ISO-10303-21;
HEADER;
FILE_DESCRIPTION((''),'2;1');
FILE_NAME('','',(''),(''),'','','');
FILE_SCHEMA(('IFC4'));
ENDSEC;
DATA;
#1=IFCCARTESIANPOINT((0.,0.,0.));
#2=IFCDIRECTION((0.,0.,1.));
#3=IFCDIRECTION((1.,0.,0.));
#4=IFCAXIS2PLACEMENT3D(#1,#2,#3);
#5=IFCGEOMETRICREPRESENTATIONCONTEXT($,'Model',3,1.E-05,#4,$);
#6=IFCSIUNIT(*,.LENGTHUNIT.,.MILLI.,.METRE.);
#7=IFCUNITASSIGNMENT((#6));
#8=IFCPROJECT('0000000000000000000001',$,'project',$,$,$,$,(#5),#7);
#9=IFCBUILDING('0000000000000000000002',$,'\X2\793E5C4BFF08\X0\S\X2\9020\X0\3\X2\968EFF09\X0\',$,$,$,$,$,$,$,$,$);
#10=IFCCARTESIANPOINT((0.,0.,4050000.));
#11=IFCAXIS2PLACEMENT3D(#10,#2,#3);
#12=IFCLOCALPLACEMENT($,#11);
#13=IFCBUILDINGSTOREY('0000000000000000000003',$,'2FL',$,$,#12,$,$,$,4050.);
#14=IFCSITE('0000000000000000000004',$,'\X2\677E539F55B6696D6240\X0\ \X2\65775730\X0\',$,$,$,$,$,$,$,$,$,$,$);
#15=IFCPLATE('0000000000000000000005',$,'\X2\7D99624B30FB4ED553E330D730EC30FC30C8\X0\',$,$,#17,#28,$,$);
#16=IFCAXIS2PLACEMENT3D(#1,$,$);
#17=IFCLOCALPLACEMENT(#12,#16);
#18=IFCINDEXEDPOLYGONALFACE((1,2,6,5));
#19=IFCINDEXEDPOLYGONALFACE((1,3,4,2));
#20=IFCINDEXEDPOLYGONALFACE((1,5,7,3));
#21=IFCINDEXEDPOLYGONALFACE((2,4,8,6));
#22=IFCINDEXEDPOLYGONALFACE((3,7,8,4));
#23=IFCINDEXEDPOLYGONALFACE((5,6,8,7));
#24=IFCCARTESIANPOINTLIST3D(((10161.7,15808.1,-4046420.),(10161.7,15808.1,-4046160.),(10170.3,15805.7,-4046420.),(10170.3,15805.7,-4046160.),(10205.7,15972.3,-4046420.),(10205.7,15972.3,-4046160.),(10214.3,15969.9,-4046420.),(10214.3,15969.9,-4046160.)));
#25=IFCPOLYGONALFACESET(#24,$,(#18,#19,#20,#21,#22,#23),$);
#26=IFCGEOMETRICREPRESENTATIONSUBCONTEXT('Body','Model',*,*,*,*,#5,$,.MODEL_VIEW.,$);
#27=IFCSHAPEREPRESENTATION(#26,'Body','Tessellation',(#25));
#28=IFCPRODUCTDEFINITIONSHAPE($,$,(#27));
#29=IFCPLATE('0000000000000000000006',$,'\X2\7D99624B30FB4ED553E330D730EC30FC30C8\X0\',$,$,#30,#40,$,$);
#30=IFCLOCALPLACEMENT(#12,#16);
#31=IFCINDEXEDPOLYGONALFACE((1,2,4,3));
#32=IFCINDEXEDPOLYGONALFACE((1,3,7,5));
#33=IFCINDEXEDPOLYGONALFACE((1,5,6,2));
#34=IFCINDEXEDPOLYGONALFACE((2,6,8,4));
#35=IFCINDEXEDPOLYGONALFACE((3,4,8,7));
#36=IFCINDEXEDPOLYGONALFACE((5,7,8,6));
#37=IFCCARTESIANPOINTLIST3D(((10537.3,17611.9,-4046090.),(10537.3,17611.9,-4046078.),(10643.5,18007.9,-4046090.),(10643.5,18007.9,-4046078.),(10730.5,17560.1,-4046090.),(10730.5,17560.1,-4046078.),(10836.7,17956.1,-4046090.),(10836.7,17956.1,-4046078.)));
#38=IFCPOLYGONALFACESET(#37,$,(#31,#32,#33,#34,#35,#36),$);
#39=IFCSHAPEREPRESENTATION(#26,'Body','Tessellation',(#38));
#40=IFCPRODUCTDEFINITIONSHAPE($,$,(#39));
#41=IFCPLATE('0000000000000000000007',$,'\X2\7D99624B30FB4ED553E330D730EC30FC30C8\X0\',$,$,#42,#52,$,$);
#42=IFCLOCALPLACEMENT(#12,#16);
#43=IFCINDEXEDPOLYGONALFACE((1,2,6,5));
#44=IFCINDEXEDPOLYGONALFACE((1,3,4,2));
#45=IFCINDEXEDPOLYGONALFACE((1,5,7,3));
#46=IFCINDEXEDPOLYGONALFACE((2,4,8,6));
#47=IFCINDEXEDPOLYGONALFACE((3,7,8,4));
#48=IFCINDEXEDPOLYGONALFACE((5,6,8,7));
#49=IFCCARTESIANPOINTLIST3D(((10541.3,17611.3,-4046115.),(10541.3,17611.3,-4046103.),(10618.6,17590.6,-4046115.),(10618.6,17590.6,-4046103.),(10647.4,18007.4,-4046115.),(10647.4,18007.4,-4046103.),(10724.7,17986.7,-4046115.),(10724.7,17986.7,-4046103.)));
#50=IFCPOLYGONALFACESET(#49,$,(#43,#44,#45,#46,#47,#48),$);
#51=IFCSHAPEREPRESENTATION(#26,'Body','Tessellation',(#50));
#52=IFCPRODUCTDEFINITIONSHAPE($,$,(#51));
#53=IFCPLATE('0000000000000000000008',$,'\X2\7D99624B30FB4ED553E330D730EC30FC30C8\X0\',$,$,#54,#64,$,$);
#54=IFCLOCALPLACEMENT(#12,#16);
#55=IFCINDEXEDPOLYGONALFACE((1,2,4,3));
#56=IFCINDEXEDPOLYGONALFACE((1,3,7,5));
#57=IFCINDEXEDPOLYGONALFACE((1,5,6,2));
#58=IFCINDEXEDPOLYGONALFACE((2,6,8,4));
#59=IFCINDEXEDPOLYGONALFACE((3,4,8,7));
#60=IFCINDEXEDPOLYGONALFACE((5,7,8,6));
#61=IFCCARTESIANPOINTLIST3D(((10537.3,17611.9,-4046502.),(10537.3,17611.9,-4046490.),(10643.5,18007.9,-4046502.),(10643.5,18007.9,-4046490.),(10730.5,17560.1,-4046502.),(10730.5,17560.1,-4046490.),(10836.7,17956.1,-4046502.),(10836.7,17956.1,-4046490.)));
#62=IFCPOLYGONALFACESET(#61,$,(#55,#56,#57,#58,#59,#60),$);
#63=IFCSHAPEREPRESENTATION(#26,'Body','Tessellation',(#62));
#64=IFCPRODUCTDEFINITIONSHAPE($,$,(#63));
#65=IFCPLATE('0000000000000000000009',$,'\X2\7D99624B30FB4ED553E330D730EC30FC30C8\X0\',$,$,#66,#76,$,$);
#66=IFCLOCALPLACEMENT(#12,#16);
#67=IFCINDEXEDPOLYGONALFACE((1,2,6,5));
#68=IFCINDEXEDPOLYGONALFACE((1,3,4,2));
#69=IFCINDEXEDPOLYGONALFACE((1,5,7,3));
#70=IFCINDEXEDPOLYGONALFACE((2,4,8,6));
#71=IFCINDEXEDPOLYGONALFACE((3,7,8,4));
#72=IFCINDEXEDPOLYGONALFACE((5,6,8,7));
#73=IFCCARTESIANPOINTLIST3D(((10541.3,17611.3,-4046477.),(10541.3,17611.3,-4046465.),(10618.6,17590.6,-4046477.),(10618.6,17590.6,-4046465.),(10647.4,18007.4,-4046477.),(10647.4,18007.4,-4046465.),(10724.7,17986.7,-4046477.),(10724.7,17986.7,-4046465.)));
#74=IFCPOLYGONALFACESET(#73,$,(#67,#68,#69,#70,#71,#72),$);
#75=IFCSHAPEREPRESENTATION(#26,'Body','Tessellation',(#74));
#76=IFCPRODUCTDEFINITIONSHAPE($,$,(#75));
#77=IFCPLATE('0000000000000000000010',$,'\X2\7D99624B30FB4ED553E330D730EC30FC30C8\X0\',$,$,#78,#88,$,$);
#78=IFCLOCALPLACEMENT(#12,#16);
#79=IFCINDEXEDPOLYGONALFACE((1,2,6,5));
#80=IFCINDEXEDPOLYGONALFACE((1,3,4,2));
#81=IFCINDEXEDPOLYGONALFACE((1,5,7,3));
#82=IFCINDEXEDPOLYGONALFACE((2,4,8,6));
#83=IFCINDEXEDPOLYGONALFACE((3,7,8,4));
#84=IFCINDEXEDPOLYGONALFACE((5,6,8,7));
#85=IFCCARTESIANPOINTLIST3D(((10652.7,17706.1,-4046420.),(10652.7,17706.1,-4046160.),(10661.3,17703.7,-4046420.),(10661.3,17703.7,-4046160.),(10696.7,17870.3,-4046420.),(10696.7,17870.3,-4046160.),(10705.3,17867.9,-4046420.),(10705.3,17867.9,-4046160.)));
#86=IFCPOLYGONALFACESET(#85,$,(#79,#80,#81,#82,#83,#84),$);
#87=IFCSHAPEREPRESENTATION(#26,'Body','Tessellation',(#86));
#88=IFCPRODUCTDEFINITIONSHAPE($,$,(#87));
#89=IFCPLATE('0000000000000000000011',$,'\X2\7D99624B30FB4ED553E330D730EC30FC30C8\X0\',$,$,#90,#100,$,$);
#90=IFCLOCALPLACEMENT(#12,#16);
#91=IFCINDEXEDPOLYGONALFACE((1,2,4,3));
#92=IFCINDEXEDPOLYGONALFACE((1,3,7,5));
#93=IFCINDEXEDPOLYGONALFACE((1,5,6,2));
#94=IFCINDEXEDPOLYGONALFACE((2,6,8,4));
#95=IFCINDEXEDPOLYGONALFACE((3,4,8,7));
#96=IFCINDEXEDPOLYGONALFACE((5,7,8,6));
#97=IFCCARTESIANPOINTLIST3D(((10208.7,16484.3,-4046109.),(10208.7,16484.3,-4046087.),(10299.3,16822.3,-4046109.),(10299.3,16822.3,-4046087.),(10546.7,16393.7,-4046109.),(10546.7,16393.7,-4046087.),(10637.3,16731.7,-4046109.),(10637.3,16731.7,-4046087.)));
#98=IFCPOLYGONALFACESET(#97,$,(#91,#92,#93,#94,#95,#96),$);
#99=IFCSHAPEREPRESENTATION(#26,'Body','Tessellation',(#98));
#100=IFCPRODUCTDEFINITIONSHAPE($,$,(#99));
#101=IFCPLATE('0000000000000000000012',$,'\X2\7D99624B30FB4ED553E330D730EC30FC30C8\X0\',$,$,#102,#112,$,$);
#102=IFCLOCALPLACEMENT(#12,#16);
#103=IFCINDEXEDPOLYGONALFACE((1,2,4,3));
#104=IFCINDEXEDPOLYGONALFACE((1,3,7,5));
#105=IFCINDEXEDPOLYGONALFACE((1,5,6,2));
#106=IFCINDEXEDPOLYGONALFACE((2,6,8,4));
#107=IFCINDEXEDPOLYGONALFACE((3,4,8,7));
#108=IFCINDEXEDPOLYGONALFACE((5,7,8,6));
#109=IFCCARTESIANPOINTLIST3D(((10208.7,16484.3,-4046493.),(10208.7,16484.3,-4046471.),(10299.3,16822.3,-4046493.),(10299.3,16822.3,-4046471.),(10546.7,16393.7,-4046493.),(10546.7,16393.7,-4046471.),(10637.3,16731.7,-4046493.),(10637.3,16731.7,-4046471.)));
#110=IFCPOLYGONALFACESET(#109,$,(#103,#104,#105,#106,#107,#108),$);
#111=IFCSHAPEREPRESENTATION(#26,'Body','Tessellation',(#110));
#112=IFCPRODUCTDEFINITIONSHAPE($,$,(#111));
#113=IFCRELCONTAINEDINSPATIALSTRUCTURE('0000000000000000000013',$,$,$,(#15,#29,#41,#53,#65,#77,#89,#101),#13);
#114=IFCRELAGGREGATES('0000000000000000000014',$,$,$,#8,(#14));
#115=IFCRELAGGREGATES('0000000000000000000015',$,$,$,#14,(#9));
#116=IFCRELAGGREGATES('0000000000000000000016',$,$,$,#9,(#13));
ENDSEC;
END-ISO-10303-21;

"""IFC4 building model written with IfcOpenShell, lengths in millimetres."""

from ifc_helpers import new_model, si_unit, frame, origin, origin_with_axes, place, context, subcontext, project, spatial, rectangle, extrude, element, save


model = new_model("IFC4")

# Units and contexts
model_context = context("Model", 3, precision=1e-05, world=origin_with_axes())
body_context = subcontext(model_context, "Body", "Model", "MODEL_VIEW")
ifc_project = project(units=[si_unit("LENGTHUNIT", "METRE", prefix="MILLI")], contexts=[model_context])

# Site, building, storey
site = spatial("IfcSite", under=ifc_project, Name="松原営業所 敷地")
building = spatial("IfcBuilding", under=site, Name="社屋（S造3階）")
storey_placement = place(None, frame((0.0, 0.0, 4050000.0), z_axis=(0.0, 0.0, 1.0), x_axis=(1.0, 0.0, 0.0)))
storey = spatial("IfcBuildingStorey", under=building, at=storey_placement, Name="2FL", Elevation=4050.0)

# Plates
for number, where, z_axis, x_axis, name in (
    (1, (10166.0, 15806.9, -4046290.0), (0.258819, 0.965926, 0.0), (-0.965926, 0.258819, 0.0), "継手・仕口プレート"),
):
    element("IfcPlate", number, at=place(storey_placement, frame(where, z_axis=z_axis, x_axis=x_axis)), inside=storey, Name=name, context=body_context, shape_type="SweptSolid", body=[
        extrude(rectangle(XDim=9.0, YDim=260.0), origin(), (0.0, 0.0, 1.0), 170.0),
    ])
plate_1_placement = place(storey_placement, frame((10633.9, 17586.0, -4046084.0), z_axis=(0.258819, 0.965926, 0.0), x_axis=(-0.965926, 0.258819, 0.0)))
element("IfcPlate", 2, at=plate_1_placement, inside=storey, Name="継手・仕口プレート", context=body_context, shape_type="SweptSolid", body=[
    extrude(rectangle(XDim=200.0, YDim=12.0), origin(), (0.0, 0.0, 1.0), 410.0),
])
plate_2_placement = place(storey_placement, frame((10579.9, 17601.0, -4046109.0), z_axis=(0.258819, 0.965926, 0.0), x_axis=(-0.965926, 0.258819, 0.0)))
element("IfcPlate", 3, at=plate_2_placement, inside=storey, Name="継手・仕口プレート", context=body_context, shape_type="SweptSolid", body=[
    extrude(rectangle(XDim=80.0, YDim=12.0), origin(), (0.0, 0.0, 1.0), 410.0),
])
plate_3_placement = place(storey_placement, frame((10633.9, 17586.0, -4046496.0), z_axis=(0.258819, 0.965926, 0.0), x_axis=(-0.965926, 0.258819, 0.0)))
element("IfcPlate", 4, at=plate_3_placement, inside=storey, Name="継手・仕口プレート", context=body_context, shape_type="SweptSolid", body=[
    extrude(rectangle(XDim=200.0, YDim=12.0), origin(), (0.0, 0.0, 1.0), 410.0),
])
plate_4_placement = place(storey_placement, frame((10579.9, 17601.0, -4046471.0), z_axis=(0.258819, 0.965926, 0.0), x_axis=(-0.965926, 0.258819, 0.0)))
element("IfcPlate", 5, at=plate_4_placement, inside=storey, Name="継手・仕口プレート", context=body_context, shape_type="SweptSolid", body=[
    extrude(rectangle(XDim=80.0, YDim=12.0), origin(), (0.0, 0.0, 1.0), 410.0),
])
plate_5_placement = place(storey_placement, frame((10657.0, 17704.9, -4046290.0), z_axis=(0.258819, 0.965926, 0.0), x_axis=(-0.965926, 0.258819, 0.0)))
element("IfcPlate", 6, at=plate_5_placement, inside=storey, Name="継手・仕口プレート", context=body_context, shape_type="SweptSolid", body=[
    extrude(rectangle(XDim=9.0, YDim=260.0), origin(), (0.0, 0.0, 1.0), 170.0),
])
for number, where, z_axis, x_axis, name in (
    (7, (10254.0, 16653.3, -4046098.0), (0.965926, -0.258819, 0.0), (0.258819, 0.965926, 0.0), "継手・仕口プレート"),
    (8, (10254.0, 16653.3, -4046482.0), (0.965926, -0.258819, 0.0), (0.258819, 0.965926, 0.0), "継手・仕口プレート"),
):
    element("IfcPlate", number, at=place(storey_placement, frame(where, z_axis=z_axis, x_axis=x_axis)), inside=storey, Name=name, context=body_context, shape_type="SweptSolid", body=[
        extrude(rectangle(XDim=350.0, YDim=22.0), origin(), (0.0, 0.0, 1.0), 350.0),
    ])

save(model, "model.ifc")
